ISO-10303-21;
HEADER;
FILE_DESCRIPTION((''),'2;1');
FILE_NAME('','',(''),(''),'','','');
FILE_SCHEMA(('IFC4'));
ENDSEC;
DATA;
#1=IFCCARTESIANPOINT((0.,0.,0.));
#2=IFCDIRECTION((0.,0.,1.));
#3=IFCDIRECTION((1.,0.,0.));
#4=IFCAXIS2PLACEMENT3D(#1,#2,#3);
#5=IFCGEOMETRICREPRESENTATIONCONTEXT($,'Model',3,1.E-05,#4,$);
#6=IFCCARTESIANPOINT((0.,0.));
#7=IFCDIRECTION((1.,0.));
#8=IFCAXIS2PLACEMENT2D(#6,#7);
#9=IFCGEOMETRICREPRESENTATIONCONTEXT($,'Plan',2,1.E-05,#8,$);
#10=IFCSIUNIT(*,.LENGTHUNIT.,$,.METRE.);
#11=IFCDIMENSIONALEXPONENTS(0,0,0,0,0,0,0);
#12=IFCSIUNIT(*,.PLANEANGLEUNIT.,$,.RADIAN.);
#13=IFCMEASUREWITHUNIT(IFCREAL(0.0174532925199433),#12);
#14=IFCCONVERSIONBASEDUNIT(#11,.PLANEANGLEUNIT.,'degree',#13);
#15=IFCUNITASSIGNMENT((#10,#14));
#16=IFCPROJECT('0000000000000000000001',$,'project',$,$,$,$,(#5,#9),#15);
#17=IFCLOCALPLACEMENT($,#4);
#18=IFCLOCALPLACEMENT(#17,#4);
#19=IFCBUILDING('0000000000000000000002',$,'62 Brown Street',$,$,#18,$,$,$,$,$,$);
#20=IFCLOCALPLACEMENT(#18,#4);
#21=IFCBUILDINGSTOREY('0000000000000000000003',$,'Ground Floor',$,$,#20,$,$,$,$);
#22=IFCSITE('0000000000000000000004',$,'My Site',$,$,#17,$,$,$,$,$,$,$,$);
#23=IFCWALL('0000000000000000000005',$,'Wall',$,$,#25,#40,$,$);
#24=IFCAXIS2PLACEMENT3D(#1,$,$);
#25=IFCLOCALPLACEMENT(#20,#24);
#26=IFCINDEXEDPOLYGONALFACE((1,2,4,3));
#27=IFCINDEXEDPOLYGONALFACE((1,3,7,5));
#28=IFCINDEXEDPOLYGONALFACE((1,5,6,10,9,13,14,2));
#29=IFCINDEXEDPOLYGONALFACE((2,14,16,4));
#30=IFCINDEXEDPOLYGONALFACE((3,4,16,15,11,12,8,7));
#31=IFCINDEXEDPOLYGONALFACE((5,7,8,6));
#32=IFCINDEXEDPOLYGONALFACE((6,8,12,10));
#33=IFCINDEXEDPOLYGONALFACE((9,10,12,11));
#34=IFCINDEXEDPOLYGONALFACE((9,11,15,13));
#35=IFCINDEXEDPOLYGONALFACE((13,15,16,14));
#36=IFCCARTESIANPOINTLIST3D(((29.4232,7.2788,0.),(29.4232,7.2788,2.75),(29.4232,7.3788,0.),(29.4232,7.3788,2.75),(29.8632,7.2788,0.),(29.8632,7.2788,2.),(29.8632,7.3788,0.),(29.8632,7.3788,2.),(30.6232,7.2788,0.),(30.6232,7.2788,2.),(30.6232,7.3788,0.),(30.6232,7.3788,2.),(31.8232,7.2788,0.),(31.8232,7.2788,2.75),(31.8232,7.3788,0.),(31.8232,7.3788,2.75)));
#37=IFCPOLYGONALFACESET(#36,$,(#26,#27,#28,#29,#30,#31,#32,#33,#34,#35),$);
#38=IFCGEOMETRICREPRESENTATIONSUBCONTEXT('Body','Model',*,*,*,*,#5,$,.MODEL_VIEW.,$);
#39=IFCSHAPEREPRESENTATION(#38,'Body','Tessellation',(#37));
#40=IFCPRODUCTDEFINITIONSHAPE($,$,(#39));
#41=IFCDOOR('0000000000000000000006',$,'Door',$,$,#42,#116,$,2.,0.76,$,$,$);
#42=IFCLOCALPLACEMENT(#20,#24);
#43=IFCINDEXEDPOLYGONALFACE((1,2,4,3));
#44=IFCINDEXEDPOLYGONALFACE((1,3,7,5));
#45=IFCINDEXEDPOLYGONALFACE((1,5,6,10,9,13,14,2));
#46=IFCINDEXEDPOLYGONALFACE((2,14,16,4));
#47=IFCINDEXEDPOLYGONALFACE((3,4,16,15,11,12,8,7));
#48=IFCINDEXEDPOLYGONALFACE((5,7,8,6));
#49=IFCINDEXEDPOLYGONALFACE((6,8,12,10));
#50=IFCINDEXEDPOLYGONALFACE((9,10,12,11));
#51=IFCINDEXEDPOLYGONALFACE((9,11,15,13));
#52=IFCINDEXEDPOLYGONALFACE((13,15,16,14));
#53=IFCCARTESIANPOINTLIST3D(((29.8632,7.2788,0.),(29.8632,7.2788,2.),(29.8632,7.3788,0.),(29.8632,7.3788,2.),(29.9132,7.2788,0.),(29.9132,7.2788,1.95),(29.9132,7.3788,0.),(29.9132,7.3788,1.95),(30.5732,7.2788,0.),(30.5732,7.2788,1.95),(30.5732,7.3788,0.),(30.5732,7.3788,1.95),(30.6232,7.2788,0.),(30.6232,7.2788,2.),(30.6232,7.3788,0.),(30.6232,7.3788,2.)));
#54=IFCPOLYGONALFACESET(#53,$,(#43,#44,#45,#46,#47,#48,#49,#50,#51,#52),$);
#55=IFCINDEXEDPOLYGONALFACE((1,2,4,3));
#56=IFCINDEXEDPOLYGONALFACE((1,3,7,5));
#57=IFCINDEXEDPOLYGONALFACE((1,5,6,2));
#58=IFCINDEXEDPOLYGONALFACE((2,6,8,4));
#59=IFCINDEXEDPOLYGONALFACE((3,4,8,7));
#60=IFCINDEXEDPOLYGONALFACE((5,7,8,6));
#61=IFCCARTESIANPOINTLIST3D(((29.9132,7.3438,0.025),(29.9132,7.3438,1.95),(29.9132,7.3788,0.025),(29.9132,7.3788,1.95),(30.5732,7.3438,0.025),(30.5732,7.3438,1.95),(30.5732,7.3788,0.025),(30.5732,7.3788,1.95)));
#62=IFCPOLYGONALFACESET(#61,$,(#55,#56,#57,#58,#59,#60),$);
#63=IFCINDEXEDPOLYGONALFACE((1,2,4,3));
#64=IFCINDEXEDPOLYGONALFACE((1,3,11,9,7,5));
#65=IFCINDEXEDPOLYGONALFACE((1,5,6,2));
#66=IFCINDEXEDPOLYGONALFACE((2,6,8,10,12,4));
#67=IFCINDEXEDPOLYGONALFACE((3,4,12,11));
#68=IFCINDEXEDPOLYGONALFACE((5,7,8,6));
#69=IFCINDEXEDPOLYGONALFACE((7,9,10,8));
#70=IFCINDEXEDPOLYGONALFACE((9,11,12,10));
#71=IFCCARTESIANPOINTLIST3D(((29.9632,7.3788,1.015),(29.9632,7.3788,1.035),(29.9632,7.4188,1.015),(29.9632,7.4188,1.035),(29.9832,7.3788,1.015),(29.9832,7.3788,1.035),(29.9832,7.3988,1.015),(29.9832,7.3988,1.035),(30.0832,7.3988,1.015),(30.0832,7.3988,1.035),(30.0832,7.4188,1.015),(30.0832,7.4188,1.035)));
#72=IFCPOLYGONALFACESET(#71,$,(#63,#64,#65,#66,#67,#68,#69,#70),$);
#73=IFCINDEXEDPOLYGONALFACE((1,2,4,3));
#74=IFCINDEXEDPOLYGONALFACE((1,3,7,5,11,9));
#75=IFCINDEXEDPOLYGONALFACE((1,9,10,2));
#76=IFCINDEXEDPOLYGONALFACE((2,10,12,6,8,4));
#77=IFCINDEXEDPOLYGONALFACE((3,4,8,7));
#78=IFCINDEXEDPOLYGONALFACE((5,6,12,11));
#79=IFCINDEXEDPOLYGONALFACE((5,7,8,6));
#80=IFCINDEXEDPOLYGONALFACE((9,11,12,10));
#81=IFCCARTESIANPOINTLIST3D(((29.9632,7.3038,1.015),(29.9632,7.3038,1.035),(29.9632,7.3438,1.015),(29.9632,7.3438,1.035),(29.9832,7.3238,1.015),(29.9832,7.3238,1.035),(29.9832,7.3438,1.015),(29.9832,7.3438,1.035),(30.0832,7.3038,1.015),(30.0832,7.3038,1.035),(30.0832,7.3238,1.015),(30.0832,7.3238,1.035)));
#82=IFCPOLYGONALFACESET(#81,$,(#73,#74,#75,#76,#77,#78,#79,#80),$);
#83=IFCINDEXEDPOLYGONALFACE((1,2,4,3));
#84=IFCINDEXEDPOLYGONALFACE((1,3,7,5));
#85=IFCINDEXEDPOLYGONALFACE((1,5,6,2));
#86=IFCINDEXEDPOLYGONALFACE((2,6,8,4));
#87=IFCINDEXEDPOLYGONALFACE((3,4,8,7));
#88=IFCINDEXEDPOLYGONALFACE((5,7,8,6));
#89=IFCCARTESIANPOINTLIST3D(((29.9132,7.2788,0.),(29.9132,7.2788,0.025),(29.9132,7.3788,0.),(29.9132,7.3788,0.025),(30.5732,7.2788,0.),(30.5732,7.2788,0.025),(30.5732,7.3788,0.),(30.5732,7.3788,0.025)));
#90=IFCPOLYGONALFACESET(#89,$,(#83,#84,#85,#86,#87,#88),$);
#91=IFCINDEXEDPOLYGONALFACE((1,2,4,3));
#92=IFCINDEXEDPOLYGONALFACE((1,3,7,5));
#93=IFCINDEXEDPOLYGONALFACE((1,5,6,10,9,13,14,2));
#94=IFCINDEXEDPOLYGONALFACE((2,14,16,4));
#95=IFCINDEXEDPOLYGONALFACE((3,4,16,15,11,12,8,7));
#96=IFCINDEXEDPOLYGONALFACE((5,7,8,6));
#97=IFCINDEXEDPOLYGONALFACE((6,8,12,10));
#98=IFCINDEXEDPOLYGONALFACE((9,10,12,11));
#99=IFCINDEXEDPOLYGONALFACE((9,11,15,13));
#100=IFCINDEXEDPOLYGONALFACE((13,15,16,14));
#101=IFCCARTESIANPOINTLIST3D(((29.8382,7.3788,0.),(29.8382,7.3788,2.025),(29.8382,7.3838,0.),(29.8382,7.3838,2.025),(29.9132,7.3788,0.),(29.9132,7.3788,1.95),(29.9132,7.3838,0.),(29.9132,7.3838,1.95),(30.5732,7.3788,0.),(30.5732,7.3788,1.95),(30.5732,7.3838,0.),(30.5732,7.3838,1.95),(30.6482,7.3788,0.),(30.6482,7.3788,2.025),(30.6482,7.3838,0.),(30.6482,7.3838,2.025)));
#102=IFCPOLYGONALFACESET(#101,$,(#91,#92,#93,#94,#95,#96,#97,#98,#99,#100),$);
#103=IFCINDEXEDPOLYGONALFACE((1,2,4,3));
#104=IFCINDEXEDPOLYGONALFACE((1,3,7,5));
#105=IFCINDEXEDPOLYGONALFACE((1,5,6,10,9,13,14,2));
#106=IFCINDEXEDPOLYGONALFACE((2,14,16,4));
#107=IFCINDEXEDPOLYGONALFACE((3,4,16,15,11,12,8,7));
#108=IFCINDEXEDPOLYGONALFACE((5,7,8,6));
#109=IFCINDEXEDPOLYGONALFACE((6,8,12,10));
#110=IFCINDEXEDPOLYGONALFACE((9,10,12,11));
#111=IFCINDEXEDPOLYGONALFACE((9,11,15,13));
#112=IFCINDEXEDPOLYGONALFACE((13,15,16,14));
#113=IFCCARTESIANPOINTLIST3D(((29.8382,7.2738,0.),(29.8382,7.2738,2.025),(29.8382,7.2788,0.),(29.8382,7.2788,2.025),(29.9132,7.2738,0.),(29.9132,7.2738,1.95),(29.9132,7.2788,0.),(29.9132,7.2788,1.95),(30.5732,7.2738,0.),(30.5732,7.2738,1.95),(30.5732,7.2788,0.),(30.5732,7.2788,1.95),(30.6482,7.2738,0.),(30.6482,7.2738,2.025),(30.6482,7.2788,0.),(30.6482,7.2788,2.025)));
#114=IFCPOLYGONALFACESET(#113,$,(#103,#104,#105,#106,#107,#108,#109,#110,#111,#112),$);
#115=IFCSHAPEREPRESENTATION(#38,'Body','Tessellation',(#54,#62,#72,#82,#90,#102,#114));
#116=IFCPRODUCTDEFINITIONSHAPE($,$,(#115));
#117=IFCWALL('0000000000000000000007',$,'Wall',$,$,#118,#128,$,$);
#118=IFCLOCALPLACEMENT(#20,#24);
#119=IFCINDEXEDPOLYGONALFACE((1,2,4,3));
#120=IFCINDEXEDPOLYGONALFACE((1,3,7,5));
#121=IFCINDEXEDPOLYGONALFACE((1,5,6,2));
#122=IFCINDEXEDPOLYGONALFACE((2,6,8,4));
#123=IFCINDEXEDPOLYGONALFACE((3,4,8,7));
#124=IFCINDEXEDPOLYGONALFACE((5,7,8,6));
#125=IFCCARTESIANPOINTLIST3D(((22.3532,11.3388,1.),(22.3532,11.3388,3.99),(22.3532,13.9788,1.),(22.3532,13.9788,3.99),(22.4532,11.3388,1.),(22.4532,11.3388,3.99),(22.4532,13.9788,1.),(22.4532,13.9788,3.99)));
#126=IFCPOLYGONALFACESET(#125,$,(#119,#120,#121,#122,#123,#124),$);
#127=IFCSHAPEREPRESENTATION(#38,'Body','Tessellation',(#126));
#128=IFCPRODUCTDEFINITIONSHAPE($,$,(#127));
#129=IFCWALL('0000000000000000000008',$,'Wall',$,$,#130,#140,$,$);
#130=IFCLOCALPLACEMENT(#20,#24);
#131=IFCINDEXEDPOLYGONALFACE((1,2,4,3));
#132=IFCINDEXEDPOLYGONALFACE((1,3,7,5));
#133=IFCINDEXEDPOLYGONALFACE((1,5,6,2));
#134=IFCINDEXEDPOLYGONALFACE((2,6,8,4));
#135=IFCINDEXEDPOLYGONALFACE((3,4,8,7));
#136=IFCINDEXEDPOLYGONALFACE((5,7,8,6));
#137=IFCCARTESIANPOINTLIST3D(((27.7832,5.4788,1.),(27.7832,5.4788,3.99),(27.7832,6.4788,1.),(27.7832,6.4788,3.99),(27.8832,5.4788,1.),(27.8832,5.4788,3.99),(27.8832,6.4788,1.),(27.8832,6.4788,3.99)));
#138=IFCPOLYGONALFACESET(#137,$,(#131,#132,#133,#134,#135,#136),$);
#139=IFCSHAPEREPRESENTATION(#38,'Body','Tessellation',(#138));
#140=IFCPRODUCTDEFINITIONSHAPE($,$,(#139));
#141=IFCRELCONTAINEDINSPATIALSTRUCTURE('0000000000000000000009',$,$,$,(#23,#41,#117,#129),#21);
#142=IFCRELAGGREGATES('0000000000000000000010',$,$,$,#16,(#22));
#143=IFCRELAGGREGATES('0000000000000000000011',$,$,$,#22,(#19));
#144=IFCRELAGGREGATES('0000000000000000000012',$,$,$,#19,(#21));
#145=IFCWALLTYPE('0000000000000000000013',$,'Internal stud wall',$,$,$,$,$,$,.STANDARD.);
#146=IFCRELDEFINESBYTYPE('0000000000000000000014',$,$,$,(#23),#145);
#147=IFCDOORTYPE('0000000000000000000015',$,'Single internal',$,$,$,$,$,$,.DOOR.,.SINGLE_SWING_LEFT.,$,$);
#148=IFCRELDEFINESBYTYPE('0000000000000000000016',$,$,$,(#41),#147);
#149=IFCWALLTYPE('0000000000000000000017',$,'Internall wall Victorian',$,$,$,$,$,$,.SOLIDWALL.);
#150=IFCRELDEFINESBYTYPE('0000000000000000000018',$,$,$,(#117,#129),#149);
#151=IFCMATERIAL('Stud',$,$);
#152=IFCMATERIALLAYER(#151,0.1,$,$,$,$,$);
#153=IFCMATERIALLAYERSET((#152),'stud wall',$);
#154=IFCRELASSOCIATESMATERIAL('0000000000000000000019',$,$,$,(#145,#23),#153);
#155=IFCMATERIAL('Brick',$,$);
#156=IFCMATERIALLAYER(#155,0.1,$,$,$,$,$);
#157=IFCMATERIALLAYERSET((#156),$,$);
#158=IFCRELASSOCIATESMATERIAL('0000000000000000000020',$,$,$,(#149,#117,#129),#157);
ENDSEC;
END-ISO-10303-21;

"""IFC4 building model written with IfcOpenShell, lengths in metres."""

from ifc_helpers import new_model, entity, si_unit, converted_unit, frame, origin_with_axes, origin_2d_with_axis, place, context, subcontext, project, spatial, line, indexed_curve, outline, extrude, shape, source, transform, mapped, material, layer, layer_set, layer_usage, type_object, type_shapes, element, fill, save


model = new_model("IFC4")

# Units and contexts
model_context = context("Model", 3, precision=1e-05, world=origin_with_axes())
plan_context = context("Plan", 2, precision=1e-05, world=origin_2d_with_axis())
body_context_1 = subcontext(model_context, "Body", "Model", "MODEL_VIEW")
body_context_2 = subcontext(plan_context, "Body", "Plan", "PLAN_VIEW")
ifc_project = project(units=[si_unit("LENGTHUNIT", "METRE"), converted_unit("PLANEANGLEUNIT", "degree", entity("IfcReal", 0.0174532925199433), si_unit("PLANEANGLEUNIT", "RADIAN"), dimensions=[0, 0, 0, 0, 0, 0, 0])], contexts=[model_context, plan_context])

# Site, building, storey
site_placement = place(None, origin_with_axes())
site = spatial("IfcSite", under=ifc_project, at=site_placement, Name="My Site")
building_placement = place(site_placement, origin_with_axes())
building = spatial("IfcBuilding", under=site, at=building_placement, Name="62 Brown Street")
storey_placement = place(building_placement, origin_with_axes())
storey = spatial("IfcBuildingStorey", under=building, at=storey_placement, Name="Ground Floor")

# Shared definitions
ifc_material_1 = material(Name="Brick")

# Wall, opening, door
ifc_material_2 = material(Name="Stud")
ifc_layer_1 = layer(ifc_material_2, 0.1)
ifc_layer_set_1 = layer_set([ifc_layer_1], Name="stud wall")
ifc_layer_usage_1 = layer_usage(ifc_layer_set_1, "AXIS2", "POSITIVE", 0.0)
wall_type_1 = type_object("IfcWallType", Name="Internal stud wall", PredefinedType="STANDARD", material=ifc_layer_set_1)
wall_1_placement = place(storey_placement, frame((31.8232, 7.3788, 0.0), z_axis=(0.0, 0.0, 1.0), x_axis=(-1.0, 0.0, 0.0)))
wall_1 = element("IfcWall", 1, at=wall_1_placement, inside=storey, type_object=wall_type_1, material=ifc_layer_usage_1, Name="Wall", context=body_context_1, shape_type="SweptSolid", body=[
    extrude(outline(indexed_curve([(0.0, 0.0), (0.0, 0.1), (2.4, 0.1), (2.4, 0.0), (0.0, 0.0)], self_intersect=False)), origin_with_axes(), (0.0, 0.0, 1.0), 2.75),
])
shared_shape_1 = source(origin_with_axes(), body_context_1, "Body", "SweptSolid", [
    extrude(outline(indexed_curve([(0.0, 0.0), (0.76, 0.0), (0.76, 2.0), (0.0, 2.0)], segments=[line(1, 2, 3, 4, 1)])), frame((0.0, -0.6, 0.0), z_axis=(0.0, -1.0, 0.0), x_axis=(1.0, 0.0, 0.0)), (0.0, 0.0, -1.0), 1.2),
])
opening_1_placement = place(wall_1_placement, frame((1.2, 0.0, 0.0), z_axis=(0.0, 0.0, 1.0), x_axis=(1.0, 0.0, 0.0)))
opening_1 = element("IfcOpeningElement", 2, at=opening_1_placement, cuts=wall_1, PredefinedType="OPENING", context=body_context_1, shape_type="MappedRepresentation", body=[
    mapped(shared_shape_1, transform((0.0, 0.0, 0.0), x_axis=(1.0, 0.0, 0.0), y_axis=(0.0, 1.0, 0.0), z_axis=(0.0, 0.0, 1.0), scale=1.0)),
])
door_type_1 = type_object("IfcDoorType", Name="Single internal", OperationType="SINGLE_SWING_LEFT", PredefinedType="DOOR")
shared_shape_2 = source(origin_with_axes(), body_context_1, "Body", "SweptSolid", [
    extrude(outline(indexed_curve([(0.0, 0.0), (0.0, 2.0), (0.76, 2.0), (0.76, 0.0), (0.71, 0.0), (0.71, 1.95), (0.05, 1.95), (0.05, 0.0)], segments=[line(1, 2, 3, 4, 5, 6, 7, 8, 1)])), frame((0.0, 0.0, 0.0), z_axis=(0.0, -1.0, 0.0), x_axis=(1.0, 0.0, 0.0)), (0.0, 0.0, -1.0), 0.1),
    extrude(outline(indexed_curve([(0.0, 0.0), (0.66, 0.0), (0.66, 0.035), (0.0, 0.035)], segments=[line(1, 2, 3, 4, 1)])), frame((0.05, 0.0, 0.025), z_axis=(0.0, 0.0, 1.0), x_axis=(1.0, 0.0, 0.0)), (0.0, 0.0, 1.0), 1.925),
    extrude(outline(indexed_curve([(0.0, 0.0), (0.0, -0.04), (-0.12, -0.04), (-0.12, -0.02), (-0.02, -0.02), (-0.02, 0.0)], segments=[line(1, 2, 3, 4, 5, 6, 1)])), frame((0.66, 0.0, 1.015), z_axis=(0.0, 0.0, 1.0), x_axis=(1.0, 0.0, 0.0)), (0.0, 0.0, 1.0), 0.02),
    extrude(outline(indexed_curve([(0.0, 0.0), (0.0, 0.04), (-0.12, 0.04), (-0.12, 0.02), (-0.02, 0.02), (-0.02, 0.0)], segments=[line(1, 2, 3, 4, 5, 6, 1)])), frame((0.66, 0.035, 1.015), z_axis=(0.0, 0.0, 1.0), x_axis=(1.0, 0.0, 0.0)), (0.0, 0.0, 1.0), 0.02),
    extrude(outline(indexed_curve([(0.0, 0.0), (0.66, 0.0), (0.66, 0.1), (0.0, 0.1)], segments=[line(1, 2, 3, 4, 1)])), frame((0.05, 0.0, 0.0), z_axis=(0.0, 0.0, 1.0), x_axis=(1.0, 0.0, 0.0)), (0.0, 0.0, 1.0), 0.025),
    extrude(outline(indexed_curve([(0.0, 0.0), (0.0, 2.025), (0.81, 2.025), (0.81, 0.0), (0.735, 0.0), (0.735, 1.95), (0.075, 1.95), (0.075, 0.0)], segments=[line(1, 2, 3, 4, 5, 6, 7, 8, 1)])), frame((-0.025, -0.005, 0.0), z_axis=(0.0, -1.0, 0.0), x_axis=(1.0, 0.0, 0.0)), (0.0, 0.0, -1.0), 0.005),
    extrude(outline(indexed_curve([(0.0, 0.0), (0.0, 2.025), (0.81, 2.025), (0.81, 0.0), (0.735, 0.0), (0.735, 1.95), (0.075, 1.95), (0.075, 0.0)], segments=[line(1, 2, 3, 4, 5, 6, 7, 8, 1)])), frame((-0.025, 0.1, 0.0), z_axis=(0.0, -1.0, 0.0), x_axis=(1.0, 0.0, 0.0)), (0.0, 0.0, -1.0), 0.005),
])
shared_shape_3 = source(origin_with_axes(), body_context_2, "Body", "Curve2D", [
    entity("IfcIndexedPolyCurve", entity("IfcCartesianPointList2D", [[0.0, 0.0], [0.05, 0.0], [0.05, 0.1], [0.0, 0.1]]), [entity("IfcLineIndex", [1, 2, 3, 4, 1])]),
    entity("IfcIndexedPolyCurve", entity("IfcCartesianPointList2D", [[0.76, 0.0], [0.71, 0.0], [0.71, 0.1], [0.76, 0.1]]), [entity("IfcLineIndex", [1, 2, 3, 4, 1])]),
    entity("IfcTrimmedCurve", entity("IfcEllipse", entity("IfcAxis2Placement2D", entity("IfcCartesianPoint", [0.085, 0.1]), entity("IfcDirection", [1.0, 0.0])), 0.625, 0.66), [entity("IfcCartesianPoint", [0.71, 0.1])], [entity("IfcCartesianPoint", [0.085, 0.76])], True, "CARTESIAN"),
    entity("IfcIndexedPolyCurve", entity("IfcCartesianPointList2D", [[0.05, 0.1], [0.085, 0.1], [0.085, 0.76], [0.05, 0.76]]), [entity("IfcLineIndex", [1, 2, 3, 4, 1])]),
])
type_shapes(door_type_1, [shared_shape_2, shared_shape_3])
door_1_placement = place(opening_1_placement, frame((0.0, 0.0, 0.0), z_axis=(0.0, 0.0, 1.0), x_axis=(1.0, 0.0, 0.0)))
door_1 = element("IfcDoor", 3, at=door_1_placement, inside=storey, type_object=door_type_1, Name="Door", OverallHeight=2.0, OverallWidth=0.76, shapes=[
    shape(body_context_1, "Body", "MappedRepresentation", [mapped(shared_shape_2, transform((0.0, 0.0, 0.0), x_axis=(1.0, 0.0, 0.0), y_axis=(0.0, 1.0, 0.0), z_axis=(0.0, 0.0, 1.0), scale=1.0))]),
    shape(body_context_2, "Body", "MappedRepresentation", [mapped(shared_shape_3, transform((0.0, 0.0, 0.0), x_axis=(1.0, 0.0, 0.0), y_axis=(0.0, 1.0, 0.0), z_axis=(0.0, 0.0, 1.0), scale=1.0))]),
])
fill(opening_1, door_1)

# Walls
ifc_layer_2 = layer(ifc_material_1, 0.1)
ifc_layer_set_2 = layer_set([ifc_layer_2])
ifc_layer_usage_2 = layer_usage(ifc_layer_set_2, "AXIS2", "POSITIVE", 0.0)
wall_type_2 = type_object("IfcWallType", Name="Internall wall Victorian", PredefinedType="SOLIDWALL", material=ifc_layer_set_2)
wall_2_placement = place(storey_placement, frame((22.4532, 11.3388, 1.0), z_axis=(0.0, 0.0, 1.0), x_axis=(0.0, 1.0, 0.0)))
element("IfcWall", 4, at=wall_2_placement, inside=storey, type_object=wall_type_2, material=ifc_layer_usage_2, Name="Wall", context=body_context_1, shape_type="SweptSolid", body=[
    extrude(outline(indexed_curve([(0.0, 0.0), (0.0, 0.1), (2.64, 0.1), (2.64, 0.0), (0.0, 0.0)], self_intersect=False)), origin_with_axes(), (0.0, 0.0, 1.0), 2.99),
])
ifc_layer_usage_3 = layer_usage(ifc_layer_set_2, "AXIS2", "POSITIVE", 0.0)
wall_3_placement = place(storey_placement, frame((27.8832, 5.4788, 1.0), z_axis=(0.0, 0.0, 1.0), x_axis=(0.0, 1.0, 0.0)))
element("IfcWall", 5, at=wall_3_placement, inside=storey, type_object=wall_type_2, material=ifc_layer_usage_3, Name="Wall", context=body_context_1, shape_type="SweptSolid", body=[
    extrude(outline(indexed_curve([(0.0, 0.0), (0.0, 0.1), (1.0, 0.1), (1.0, 0.0), (0.0, 0.0)], self_intersect=False)), origin_with_axes(), (0.0, 0.0, 1.0), 2.99),
])

save(model, "model.ifc")
